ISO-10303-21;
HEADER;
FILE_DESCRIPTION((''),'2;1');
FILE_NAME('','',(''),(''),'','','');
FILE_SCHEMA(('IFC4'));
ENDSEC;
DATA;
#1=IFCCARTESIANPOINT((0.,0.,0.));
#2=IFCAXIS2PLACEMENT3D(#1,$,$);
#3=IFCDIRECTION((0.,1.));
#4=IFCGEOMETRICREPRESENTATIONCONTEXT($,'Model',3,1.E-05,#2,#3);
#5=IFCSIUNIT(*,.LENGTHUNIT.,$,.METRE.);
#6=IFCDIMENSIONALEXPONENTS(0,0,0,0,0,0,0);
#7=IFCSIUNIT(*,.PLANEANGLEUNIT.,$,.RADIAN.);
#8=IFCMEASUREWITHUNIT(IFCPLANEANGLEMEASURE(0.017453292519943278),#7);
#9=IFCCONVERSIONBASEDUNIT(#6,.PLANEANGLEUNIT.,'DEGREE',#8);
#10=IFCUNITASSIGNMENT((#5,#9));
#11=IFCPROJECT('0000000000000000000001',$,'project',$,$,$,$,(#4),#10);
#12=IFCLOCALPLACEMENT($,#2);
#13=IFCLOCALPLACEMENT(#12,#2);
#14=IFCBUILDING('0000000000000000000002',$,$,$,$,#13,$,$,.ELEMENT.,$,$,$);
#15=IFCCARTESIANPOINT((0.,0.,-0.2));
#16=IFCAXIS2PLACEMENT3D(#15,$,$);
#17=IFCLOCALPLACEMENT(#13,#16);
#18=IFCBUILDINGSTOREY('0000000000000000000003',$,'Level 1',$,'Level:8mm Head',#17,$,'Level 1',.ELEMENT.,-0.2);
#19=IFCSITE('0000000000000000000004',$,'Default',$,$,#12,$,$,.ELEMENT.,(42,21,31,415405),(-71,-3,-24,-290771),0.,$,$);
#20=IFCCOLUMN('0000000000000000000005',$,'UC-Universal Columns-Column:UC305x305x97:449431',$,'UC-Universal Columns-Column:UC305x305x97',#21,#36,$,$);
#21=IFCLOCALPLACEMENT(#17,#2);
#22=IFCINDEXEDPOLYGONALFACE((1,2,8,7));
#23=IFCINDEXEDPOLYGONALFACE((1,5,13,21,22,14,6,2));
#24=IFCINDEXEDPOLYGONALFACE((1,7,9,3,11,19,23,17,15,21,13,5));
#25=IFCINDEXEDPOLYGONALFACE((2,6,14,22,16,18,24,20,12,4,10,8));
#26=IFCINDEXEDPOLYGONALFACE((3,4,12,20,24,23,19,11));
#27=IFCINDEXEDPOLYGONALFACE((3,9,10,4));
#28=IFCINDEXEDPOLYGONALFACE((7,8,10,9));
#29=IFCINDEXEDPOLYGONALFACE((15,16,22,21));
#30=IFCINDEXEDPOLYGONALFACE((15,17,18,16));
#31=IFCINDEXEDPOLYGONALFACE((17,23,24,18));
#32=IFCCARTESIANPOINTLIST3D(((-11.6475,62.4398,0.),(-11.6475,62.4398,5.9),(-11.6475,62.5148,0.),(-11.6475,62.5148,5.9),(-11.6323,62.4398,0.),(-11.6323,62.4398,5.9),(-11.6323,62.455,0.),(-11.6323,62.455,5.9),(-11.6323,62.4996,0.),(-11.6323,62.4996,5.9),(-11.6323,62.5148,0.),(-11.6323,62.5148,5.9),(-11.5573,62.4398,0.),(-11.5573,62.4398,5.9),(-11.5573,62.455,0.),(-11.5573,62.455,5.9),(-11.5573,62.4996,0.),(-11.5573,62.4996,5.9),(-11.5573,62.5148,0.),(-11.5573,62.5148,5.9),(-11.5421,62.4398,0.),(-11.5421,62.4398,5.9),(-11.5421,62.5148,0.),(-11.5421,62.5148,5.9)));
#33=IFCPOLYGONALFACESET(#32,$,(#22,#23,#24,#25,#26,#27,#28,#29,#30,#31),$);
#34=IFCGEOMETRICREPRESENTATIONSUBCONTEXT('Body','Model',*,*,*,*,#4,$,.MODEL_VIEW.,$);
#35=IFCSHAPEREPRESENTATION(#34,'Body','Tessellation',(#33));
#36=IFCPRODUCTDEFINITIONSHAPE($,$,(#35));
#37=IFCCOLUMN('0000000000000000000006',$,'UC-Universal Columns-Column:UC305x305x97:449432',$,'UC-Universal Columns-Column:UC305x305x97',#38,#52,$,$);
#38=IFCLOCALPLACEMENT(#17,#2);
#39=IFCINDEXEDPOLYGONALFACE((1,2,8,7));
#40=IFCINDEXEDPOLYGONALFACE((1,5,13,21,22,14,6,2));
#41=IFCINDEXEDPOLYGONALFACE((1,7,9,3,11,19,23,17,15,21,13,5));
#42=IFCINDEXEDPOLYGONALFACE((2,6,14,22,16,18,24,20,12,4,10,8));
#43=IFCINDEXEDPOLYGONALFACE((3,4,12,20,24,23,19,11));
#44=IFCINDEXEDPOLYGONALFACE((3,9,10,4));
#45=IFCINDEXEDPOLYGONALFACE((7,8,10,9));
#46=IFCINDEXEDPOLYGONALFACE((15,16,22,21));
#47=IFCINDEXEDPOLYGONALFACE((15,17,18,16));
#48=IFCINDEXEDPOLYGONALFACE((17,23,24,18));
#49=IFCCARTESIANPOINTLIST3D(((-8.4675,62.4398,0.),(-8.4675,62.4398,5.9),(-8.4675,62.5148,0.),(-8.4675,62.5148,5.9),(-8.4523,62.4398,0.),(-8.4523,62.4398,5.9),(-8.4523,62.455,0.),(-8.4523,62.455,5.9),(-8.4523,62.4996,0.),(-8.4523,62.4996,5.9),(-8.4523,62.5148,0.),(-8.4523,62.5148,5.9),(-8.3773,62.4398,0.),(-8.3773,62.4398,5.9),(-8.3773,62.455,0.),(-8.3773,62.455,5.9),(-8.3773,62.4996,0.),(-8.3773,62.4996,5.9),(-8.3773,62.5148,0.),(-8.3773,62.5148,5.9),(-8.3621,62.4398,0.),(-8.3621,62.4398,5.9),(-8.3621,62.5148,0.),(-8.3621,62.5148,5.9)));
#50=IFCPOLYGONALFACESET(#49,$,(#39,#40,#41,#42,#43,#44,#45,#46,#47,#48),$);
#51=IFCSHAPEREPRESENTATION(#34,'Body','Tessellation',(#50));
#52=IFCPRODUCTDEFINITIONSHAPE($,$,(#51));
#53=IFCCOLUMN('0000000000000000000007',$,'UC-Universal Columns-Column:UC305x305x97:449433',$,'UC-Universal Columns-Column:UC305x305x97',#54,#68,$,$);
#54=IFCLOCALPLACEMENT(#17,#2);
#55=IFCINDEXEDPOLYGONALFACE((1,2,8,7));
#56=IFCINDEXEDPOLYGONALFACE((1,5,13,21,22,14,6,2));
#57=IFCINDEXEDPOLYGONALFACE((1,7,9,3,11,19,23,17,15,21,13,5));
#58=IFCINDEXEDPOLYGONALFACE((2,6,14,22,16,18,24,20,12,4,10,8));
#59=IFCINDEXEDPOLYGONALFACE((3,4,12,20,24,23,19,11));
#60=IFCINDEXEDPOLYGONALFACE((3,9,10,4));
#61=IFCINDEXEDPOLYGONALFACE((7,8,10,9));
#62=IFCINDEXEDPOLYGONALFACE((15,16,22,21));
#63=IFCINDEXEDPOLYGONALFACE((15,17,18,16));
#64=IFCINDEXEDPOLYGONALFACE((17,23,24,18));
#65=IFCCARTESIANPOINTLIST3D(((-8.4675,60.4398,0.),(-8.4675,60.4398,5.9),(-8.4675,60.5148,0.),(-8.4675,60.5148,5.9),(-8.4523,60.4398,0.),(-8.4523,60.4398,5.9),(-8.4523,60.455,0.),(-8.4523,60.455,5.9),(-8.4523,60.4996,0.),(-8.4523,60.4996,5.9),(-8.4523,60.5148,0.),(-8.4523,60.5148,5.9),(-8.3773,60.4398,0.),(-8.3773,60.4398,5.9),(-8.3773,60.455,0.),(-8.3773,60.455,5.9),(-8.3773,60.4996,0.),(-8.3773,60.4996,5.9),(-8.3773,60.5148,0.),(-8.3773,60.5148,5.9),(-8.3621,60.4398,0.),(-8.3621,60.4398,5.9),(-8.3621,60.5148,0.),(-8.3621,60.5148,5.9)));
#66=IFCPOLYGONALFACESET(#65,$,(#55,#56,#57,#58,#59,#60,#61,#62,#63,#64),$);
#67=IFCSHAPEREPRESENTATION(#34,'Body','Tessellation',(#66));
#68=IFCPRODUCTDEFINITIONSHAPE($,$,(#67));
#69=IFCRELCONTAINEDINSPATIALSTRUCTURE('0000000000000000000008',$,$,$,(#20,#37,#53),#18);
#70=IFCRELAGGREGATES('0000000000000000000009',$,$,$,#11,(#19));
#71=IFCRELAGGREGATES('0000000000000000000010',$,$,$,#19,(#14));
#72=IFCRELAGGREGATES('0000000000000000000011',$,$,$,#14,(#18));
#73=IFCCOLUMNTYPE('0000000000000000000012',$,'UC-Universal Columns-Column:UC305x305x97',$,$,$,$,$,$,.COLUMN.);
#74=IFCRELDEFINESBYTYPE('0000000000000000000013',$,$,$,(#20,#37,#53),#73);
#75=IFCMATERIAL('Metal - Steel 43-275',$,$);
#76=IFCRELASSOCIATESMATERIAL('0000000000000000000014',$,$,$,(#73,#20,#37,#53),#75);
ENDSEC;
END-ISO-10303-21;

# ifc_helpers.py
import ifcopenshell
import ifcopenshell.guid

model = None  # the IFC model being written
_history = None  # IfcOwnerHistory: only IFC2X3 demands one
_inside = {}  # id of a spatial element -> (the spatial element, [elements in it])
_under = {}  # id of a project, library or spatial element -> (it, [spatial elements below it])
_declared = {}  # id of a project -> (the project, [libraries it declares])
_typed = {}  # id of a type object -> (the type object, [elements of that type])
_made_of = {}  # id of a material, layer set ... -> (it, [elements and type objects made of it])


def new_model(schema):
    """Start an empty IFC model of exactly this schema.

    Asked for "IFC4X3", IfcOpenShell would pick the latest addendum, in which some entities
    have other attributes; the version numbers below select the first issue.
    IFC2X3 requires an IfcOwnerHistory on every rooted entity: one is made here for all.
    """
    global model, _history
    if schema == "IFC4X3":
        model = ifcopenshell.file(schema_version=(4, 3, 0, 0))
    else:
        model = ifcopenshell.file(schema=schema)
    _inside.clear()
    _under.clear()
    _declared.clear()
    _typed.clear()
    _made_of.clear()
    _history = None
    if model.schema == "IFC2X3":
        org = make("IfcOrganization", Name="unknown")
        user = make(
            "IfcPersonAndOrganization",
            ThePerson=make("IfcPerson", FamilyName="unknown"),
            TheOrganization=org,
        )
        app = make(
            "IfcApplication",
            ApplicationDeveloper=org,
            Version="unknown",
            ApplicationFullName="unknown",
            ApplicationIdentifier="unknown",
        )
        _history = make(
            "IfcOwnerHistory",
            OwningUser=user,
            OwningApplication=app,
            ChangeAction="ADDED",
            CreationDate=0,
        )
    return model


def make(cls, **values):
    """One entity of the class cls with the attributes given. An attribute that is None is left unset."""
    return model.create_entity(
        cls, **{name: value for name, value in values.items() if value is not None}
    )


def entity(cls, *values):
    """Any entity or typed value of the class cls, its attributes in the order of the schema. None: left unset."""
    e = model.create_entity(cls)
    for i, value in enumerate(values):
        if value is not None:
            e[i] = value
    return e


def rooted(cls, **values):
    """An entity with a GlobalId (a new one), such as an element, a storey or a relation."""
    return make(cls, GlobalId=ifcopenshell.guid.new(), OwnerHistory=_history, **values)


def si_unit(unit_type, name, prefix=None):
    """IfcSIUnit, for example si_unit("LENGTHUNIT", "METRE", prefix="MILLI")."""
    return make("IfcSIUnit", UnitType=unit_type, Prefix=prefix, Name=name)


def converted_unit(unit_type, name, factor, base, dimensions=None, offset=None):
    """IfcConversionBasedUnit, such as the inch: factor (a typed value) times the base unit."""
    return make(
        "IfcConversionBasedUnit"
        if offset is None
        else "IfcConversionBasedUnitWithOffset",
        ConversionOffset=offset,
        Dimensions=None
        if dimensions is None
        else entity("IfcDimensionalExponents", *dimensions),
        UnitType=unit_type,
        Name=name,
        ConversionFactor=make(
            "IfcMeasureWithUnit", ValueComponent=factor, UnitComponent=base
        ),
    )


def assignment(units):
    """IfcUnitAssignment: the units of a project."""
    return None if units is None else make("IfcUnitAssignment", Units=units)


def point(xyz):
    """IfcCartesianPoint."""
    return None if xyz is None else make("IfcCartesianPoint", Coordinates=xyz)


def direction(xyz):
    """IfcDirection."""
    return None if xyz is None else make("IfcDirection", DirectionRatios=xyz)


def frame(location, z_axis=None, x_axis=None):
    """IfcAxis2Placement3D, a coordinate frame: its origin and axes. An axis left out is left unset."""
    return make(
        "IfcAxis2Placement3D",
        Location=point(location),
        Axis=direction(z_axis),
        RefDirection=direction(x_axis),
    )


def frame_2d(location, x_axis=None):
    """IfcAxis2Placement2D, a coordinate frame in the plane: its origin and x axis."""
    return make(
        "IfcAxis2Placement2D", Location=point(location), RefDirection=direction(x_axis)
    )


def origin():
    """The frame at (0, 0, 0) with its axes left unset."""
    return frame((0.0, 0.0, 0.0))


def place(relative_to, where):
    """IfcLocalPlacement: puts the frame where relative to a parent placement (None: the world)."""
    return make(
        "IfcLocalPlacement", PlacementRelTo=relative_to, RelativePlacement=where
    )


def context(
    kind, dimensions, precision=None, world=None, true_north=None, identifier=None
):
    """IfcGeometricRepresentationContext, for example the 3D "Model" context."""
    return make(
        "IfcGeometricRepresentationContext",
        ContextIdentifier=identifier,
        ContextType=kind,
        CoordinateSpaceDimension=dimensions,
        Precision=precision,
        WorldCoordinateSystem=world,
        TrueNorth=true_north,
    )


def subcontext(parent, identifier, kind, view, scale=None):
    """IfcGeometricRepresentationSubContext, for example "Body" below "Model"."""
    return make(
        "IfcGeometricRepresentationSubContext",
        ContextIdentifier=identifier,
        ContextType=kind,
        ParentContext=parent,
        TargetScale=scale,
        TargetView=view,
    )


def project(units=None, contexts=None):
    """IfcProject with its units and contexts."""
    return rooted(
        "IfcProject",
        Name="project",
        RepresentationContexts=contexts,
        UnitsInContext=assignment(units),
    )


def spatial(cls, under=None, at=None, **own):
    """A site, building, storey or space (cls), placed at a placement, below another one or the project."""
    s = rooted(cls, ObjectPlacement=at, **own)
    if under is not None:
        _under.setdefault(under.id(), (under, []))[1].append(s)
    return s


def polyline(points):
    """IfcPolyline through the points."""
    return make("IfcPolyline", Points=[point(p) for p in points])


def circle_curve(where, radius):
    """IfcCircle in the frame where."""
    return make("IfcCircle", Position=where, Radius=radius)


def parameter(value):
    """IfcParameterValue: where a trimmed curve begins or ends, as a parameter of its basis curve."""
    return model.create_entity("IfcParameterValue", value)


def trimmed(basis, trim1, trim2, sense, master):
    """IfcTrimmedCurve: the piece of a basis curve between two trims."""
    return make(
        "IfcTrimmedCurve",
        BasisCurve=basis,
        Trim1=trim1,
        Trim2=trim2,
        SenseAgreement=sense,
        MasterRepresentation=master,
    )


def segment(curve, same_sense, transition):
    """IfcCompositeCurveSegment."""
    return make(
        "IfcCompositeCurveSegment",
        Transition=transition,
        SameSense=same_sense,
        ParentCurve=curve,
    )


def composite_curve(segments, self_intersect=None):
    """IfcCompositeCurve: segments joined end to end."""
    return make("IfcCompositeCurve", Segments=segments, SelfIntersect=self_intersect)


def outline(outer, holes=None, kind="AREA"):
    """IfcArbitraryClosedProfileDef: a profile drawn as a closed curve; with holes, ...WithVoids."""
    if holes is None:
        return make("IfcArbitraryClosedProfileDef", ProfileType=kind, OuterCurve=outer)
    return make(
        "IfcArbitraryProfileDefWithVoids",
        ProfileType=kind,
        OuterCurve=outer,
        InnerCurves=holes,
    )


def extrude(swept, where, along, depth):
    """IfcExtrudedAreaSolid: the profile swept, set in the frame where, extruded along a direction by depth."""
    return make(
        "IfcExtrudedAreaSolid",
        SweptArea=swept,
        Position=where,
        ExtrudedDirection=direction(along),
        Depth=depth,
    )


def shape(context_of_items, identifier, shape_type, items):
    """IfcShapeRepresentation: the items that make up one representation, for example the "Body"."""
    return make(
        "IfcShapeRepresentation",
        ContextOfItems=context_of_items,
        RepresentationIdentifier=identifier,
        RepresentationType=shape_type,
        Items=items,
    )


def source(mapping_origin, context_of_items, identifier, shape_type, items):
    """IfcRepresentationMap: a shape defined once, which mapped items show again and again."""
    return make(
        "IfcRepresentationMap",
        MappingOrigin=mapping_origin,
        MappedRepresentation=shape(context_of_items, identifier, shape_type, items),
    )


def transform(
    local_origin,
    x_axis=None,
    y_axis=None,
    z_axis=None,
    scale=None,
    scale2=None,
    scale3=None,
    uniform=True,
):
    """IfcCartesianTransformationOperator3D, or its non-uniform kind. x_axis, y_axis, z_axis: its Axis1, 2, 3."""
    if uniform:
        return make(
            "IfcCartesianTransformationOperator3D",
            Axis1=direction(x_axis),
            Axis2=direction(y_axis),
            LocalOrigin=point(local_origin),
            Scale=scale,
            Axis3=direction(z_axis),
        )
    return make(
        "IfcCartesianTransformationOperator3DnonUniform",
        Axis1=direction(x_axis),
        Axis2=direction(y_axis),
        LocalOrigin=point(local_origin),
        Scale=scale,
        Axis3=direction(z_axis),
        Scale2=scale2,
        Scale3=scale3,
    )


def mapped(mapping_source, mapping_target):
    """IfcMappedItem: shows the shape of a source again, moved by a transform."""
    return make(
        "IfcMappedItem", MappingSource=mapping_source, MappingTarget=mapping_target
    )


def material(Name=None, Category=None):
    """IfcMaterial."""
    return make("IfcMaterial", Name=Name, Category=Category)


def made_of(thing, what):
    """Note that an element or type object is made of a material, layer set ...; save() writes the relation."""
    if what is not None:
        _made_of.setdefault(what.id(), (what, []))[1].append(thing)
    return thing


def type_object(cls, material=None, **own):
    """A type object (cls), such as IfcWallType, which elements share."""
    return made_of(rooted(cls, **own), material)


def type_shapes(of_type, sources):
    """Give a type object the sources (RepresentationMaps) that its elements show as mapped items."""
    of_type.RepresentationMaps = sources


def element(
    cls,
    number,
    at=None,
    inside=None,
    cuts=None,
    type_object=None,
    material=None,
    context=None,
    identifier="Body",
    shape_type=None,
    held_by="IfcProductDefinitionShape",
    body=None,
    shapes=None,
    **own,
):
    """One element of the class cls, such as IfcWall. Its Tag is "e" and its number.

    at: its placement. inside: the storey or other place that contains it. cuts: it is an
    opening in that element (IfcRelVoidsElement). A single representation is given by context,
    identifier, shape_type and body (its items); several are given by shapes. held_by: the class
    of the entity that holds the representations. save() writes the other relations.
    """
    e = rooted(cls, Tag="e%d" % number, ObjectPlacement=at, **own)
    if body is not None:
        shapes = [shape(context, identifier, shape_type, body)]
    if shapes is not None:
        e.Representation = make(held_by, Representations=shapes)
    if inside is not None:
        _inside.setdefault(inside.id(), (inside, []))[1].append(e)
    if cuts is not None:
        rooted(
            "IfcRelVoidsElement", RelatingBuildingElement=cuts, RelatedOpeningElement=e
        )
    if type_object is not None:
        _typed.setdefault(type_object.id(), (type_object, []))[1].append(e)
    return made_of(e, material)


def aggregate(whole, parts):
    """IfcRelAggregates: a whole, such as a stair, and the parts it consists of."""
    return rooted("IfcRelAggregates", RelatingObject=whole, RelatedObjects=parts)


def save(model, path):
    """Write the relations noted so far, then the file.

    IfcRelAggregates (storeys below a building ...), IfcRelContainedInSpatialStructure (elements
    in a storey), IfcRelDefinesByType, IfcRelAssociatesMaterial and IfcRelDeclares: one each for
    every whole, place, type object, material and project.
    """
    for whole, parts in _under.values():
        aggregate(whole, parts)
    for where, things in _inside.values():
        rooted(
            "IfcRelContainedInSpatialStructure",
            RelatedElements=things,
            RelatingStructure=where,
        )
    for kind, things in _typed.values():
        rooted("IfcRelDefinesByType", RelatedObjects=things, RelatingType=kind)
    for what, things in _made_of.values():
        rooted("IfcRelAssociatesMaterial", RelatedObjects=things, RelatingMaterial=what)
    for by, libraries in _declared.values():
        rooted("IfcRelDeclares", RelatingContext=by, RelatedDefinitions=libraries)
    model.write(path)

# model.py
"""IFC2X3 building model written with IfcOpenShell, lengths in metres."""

from ifc_helpers import new_model, entity, si_unit, converted_unit, direction, frame, frame_2d, origin, place, context, subcontext, project, spatial, polyline, circle_curve, parameter, trimmed, segment, composite_curve, outline, extrude, source, transform, mapped, material, type_object, type_shapes, element, save


model = new_model("IFC2X3")

# Units and contexts
model_context = context("Model", 3, precision=1e-05, world=origin(), true_north=direction((0.0, 1.0)))
body_context = subcontext(model_context, "Body", "Model", "MODEL_VIEW")
ifc_project = project(units=[si_unit("LENGTHUNIT", "METRE"), converted_unit("PLANEANGLEUNIT", "DEGREE", entity("IfcPlaneAngleMeasure", 0.017453292519943278), si_unit("PLANEANGLEUNIT", "RADIAN"), dimensions=[0, 0, 0, 0, 0, 0, 0])], contexts=[model_context])

# Site, building, storey
site_placement = place(None, origin())
site = spatial("IfcSite", under=ifc_project, at=site_placement, Name="Default", CompositionType="ELEMENT", RefLatitude=(42, 21, 31, 415405), RefLongitude=(-71, -3, -24, -290771), RefElevation=0.0)
building_placement = place(site_placement, origin())
building = spatial("IfcBuilding", under=site, at=building_placement, CompositionType="ELEMENT")
storey_placement = place(building_placement, frame((0.0, 0.0, -0.2)))
storey = spatial("IfcBuildingStorey", under=building, at=storey_placement, Name="Level 1", ObjectType="Level:8mm Head", LongName="Level 1", CompositionType="ELEMENT", Elevation=-0.2)

# Columns
ifc_material = material(Name="Metal - Steel 43-275")
column_type = type_object("IfcColumnType", Name="UC-Universal Columns-Column:UC305x305x97", PredefinedType="COLUMN", material=ifc_material)
shared_shape = source(origin(), body_context, "Body", "SweptSolid", [
    extrude(outline(composite_curve([segment(polyline([(-0.0375, -0.0375), (0.0375, -0.0375)]), True, "CONTINUOUS"), segment(polyline([(0.0375, -0.0375), (0.0527, -0.0375)]), True, "CONTINUOUS"), segment(trimmed(circle_curve(frame_2d((0.0527, -0.0223), x_axis=(-1.0, 0.0)), 0.0152), [parameter(0.0)], [parameter(90.0)], True, "PARAMETER"), False, "CONTINUOUS"), segment(polyline([(0.0375, -0.0223), (0.0375, 0.0223)]), True, "CONTINUOUS"), segment(trimmed(circle_curve(frame_2d((0.0527, 0.0223), x_axis=(-1.0, 0.0)), 0.0152), [parameter(270.0)], [parameter(0.0)], True, "PARAMETER"), False, "CONTINUOUS"), segment(polyline([(0.0527, 0.0375), (0.0375, 0.0375)]), True, "CONTINUOUS"), segment(polyline([(0.0375, 0.0375), (-0.0375, 0.0375)]), True, "CONTINUOUS"), segment(polyline([(-0.0375, 0.0375), (-0.0527, 0.0375)]), True, "CONTINUOUS"), segment(trimmed(circle_curve(frame_2d((-0.0527, 0.0223), x_axis=(-1.0, 0.0)), 0.0152), [parameter(180.0)], [parameter(270.0)], True, "PARAMETER"), False, "CONTINUOUS"), segment(polyline([(-0.0375, 0.0223), (-0.0375, -0.0223)]), True, "CONTINUOUS"), segment(trimmed(circle_curve(frame_2d((-0.0527, -0.0223), x_axis=(-1.0, 0.0)), 0.0152), [parameter(90.0)], [parameter(180.0)], True, "PARAMETER"), False, "CONTINUOUS"), segment(polyline([(-0.0527, -0.0375), (-0.0375, -0.0375)]), True, "CONTINUOUS")], self_intersect=False)), frame((0.0, 0.0, -0.2), z_axis=(0.0, 0.0, 1.0), x_axis=(-1.0, 0.0, 0.0)), (0.0, 0.0, 1.0), 5.9),
])
type_shapes(column_type, [shared_shape])
for number, where, z_axis, x_axis, name in (
    (1, (-11.5948, 62.4773, 0.2), (0.0, 0.0, 1.0), (-1.0, 0.0, 0.0), "UC-Universal Columns-Column:UC305x305x97:449431"),
    (2, (-8.4148, 62.4773, 0.2), (0.0, 0.0, 1.0), (-1.0, 0.0, 0.0), "UC-Universal Columns-Column:UC305x305x97:449432"),
    (3, (-8.4148, 60.4773, 0.2), (0.0, 0.0, 1.0), (-1.0, 0.0, 0.0), "UC-Universal Columns-Column:UC305x305x97:449433"),
):
    element("IfcColumn", number, at=place(storey_placement, frame(where, z_axis=z_axis, x_axis=x_axis)), inside=storey, type_object=column_type, material=ifc_material, Name=name, ObjectType="UC-Universal Columns-Column:UC305x305x97", context=body_context, shape_type="MappedRepresentation", body=[
        mapped(shared_shape, transform((0.0, 0.0, 0.0), scale=1.0)),
    ])

save(model, "model.ifc")
